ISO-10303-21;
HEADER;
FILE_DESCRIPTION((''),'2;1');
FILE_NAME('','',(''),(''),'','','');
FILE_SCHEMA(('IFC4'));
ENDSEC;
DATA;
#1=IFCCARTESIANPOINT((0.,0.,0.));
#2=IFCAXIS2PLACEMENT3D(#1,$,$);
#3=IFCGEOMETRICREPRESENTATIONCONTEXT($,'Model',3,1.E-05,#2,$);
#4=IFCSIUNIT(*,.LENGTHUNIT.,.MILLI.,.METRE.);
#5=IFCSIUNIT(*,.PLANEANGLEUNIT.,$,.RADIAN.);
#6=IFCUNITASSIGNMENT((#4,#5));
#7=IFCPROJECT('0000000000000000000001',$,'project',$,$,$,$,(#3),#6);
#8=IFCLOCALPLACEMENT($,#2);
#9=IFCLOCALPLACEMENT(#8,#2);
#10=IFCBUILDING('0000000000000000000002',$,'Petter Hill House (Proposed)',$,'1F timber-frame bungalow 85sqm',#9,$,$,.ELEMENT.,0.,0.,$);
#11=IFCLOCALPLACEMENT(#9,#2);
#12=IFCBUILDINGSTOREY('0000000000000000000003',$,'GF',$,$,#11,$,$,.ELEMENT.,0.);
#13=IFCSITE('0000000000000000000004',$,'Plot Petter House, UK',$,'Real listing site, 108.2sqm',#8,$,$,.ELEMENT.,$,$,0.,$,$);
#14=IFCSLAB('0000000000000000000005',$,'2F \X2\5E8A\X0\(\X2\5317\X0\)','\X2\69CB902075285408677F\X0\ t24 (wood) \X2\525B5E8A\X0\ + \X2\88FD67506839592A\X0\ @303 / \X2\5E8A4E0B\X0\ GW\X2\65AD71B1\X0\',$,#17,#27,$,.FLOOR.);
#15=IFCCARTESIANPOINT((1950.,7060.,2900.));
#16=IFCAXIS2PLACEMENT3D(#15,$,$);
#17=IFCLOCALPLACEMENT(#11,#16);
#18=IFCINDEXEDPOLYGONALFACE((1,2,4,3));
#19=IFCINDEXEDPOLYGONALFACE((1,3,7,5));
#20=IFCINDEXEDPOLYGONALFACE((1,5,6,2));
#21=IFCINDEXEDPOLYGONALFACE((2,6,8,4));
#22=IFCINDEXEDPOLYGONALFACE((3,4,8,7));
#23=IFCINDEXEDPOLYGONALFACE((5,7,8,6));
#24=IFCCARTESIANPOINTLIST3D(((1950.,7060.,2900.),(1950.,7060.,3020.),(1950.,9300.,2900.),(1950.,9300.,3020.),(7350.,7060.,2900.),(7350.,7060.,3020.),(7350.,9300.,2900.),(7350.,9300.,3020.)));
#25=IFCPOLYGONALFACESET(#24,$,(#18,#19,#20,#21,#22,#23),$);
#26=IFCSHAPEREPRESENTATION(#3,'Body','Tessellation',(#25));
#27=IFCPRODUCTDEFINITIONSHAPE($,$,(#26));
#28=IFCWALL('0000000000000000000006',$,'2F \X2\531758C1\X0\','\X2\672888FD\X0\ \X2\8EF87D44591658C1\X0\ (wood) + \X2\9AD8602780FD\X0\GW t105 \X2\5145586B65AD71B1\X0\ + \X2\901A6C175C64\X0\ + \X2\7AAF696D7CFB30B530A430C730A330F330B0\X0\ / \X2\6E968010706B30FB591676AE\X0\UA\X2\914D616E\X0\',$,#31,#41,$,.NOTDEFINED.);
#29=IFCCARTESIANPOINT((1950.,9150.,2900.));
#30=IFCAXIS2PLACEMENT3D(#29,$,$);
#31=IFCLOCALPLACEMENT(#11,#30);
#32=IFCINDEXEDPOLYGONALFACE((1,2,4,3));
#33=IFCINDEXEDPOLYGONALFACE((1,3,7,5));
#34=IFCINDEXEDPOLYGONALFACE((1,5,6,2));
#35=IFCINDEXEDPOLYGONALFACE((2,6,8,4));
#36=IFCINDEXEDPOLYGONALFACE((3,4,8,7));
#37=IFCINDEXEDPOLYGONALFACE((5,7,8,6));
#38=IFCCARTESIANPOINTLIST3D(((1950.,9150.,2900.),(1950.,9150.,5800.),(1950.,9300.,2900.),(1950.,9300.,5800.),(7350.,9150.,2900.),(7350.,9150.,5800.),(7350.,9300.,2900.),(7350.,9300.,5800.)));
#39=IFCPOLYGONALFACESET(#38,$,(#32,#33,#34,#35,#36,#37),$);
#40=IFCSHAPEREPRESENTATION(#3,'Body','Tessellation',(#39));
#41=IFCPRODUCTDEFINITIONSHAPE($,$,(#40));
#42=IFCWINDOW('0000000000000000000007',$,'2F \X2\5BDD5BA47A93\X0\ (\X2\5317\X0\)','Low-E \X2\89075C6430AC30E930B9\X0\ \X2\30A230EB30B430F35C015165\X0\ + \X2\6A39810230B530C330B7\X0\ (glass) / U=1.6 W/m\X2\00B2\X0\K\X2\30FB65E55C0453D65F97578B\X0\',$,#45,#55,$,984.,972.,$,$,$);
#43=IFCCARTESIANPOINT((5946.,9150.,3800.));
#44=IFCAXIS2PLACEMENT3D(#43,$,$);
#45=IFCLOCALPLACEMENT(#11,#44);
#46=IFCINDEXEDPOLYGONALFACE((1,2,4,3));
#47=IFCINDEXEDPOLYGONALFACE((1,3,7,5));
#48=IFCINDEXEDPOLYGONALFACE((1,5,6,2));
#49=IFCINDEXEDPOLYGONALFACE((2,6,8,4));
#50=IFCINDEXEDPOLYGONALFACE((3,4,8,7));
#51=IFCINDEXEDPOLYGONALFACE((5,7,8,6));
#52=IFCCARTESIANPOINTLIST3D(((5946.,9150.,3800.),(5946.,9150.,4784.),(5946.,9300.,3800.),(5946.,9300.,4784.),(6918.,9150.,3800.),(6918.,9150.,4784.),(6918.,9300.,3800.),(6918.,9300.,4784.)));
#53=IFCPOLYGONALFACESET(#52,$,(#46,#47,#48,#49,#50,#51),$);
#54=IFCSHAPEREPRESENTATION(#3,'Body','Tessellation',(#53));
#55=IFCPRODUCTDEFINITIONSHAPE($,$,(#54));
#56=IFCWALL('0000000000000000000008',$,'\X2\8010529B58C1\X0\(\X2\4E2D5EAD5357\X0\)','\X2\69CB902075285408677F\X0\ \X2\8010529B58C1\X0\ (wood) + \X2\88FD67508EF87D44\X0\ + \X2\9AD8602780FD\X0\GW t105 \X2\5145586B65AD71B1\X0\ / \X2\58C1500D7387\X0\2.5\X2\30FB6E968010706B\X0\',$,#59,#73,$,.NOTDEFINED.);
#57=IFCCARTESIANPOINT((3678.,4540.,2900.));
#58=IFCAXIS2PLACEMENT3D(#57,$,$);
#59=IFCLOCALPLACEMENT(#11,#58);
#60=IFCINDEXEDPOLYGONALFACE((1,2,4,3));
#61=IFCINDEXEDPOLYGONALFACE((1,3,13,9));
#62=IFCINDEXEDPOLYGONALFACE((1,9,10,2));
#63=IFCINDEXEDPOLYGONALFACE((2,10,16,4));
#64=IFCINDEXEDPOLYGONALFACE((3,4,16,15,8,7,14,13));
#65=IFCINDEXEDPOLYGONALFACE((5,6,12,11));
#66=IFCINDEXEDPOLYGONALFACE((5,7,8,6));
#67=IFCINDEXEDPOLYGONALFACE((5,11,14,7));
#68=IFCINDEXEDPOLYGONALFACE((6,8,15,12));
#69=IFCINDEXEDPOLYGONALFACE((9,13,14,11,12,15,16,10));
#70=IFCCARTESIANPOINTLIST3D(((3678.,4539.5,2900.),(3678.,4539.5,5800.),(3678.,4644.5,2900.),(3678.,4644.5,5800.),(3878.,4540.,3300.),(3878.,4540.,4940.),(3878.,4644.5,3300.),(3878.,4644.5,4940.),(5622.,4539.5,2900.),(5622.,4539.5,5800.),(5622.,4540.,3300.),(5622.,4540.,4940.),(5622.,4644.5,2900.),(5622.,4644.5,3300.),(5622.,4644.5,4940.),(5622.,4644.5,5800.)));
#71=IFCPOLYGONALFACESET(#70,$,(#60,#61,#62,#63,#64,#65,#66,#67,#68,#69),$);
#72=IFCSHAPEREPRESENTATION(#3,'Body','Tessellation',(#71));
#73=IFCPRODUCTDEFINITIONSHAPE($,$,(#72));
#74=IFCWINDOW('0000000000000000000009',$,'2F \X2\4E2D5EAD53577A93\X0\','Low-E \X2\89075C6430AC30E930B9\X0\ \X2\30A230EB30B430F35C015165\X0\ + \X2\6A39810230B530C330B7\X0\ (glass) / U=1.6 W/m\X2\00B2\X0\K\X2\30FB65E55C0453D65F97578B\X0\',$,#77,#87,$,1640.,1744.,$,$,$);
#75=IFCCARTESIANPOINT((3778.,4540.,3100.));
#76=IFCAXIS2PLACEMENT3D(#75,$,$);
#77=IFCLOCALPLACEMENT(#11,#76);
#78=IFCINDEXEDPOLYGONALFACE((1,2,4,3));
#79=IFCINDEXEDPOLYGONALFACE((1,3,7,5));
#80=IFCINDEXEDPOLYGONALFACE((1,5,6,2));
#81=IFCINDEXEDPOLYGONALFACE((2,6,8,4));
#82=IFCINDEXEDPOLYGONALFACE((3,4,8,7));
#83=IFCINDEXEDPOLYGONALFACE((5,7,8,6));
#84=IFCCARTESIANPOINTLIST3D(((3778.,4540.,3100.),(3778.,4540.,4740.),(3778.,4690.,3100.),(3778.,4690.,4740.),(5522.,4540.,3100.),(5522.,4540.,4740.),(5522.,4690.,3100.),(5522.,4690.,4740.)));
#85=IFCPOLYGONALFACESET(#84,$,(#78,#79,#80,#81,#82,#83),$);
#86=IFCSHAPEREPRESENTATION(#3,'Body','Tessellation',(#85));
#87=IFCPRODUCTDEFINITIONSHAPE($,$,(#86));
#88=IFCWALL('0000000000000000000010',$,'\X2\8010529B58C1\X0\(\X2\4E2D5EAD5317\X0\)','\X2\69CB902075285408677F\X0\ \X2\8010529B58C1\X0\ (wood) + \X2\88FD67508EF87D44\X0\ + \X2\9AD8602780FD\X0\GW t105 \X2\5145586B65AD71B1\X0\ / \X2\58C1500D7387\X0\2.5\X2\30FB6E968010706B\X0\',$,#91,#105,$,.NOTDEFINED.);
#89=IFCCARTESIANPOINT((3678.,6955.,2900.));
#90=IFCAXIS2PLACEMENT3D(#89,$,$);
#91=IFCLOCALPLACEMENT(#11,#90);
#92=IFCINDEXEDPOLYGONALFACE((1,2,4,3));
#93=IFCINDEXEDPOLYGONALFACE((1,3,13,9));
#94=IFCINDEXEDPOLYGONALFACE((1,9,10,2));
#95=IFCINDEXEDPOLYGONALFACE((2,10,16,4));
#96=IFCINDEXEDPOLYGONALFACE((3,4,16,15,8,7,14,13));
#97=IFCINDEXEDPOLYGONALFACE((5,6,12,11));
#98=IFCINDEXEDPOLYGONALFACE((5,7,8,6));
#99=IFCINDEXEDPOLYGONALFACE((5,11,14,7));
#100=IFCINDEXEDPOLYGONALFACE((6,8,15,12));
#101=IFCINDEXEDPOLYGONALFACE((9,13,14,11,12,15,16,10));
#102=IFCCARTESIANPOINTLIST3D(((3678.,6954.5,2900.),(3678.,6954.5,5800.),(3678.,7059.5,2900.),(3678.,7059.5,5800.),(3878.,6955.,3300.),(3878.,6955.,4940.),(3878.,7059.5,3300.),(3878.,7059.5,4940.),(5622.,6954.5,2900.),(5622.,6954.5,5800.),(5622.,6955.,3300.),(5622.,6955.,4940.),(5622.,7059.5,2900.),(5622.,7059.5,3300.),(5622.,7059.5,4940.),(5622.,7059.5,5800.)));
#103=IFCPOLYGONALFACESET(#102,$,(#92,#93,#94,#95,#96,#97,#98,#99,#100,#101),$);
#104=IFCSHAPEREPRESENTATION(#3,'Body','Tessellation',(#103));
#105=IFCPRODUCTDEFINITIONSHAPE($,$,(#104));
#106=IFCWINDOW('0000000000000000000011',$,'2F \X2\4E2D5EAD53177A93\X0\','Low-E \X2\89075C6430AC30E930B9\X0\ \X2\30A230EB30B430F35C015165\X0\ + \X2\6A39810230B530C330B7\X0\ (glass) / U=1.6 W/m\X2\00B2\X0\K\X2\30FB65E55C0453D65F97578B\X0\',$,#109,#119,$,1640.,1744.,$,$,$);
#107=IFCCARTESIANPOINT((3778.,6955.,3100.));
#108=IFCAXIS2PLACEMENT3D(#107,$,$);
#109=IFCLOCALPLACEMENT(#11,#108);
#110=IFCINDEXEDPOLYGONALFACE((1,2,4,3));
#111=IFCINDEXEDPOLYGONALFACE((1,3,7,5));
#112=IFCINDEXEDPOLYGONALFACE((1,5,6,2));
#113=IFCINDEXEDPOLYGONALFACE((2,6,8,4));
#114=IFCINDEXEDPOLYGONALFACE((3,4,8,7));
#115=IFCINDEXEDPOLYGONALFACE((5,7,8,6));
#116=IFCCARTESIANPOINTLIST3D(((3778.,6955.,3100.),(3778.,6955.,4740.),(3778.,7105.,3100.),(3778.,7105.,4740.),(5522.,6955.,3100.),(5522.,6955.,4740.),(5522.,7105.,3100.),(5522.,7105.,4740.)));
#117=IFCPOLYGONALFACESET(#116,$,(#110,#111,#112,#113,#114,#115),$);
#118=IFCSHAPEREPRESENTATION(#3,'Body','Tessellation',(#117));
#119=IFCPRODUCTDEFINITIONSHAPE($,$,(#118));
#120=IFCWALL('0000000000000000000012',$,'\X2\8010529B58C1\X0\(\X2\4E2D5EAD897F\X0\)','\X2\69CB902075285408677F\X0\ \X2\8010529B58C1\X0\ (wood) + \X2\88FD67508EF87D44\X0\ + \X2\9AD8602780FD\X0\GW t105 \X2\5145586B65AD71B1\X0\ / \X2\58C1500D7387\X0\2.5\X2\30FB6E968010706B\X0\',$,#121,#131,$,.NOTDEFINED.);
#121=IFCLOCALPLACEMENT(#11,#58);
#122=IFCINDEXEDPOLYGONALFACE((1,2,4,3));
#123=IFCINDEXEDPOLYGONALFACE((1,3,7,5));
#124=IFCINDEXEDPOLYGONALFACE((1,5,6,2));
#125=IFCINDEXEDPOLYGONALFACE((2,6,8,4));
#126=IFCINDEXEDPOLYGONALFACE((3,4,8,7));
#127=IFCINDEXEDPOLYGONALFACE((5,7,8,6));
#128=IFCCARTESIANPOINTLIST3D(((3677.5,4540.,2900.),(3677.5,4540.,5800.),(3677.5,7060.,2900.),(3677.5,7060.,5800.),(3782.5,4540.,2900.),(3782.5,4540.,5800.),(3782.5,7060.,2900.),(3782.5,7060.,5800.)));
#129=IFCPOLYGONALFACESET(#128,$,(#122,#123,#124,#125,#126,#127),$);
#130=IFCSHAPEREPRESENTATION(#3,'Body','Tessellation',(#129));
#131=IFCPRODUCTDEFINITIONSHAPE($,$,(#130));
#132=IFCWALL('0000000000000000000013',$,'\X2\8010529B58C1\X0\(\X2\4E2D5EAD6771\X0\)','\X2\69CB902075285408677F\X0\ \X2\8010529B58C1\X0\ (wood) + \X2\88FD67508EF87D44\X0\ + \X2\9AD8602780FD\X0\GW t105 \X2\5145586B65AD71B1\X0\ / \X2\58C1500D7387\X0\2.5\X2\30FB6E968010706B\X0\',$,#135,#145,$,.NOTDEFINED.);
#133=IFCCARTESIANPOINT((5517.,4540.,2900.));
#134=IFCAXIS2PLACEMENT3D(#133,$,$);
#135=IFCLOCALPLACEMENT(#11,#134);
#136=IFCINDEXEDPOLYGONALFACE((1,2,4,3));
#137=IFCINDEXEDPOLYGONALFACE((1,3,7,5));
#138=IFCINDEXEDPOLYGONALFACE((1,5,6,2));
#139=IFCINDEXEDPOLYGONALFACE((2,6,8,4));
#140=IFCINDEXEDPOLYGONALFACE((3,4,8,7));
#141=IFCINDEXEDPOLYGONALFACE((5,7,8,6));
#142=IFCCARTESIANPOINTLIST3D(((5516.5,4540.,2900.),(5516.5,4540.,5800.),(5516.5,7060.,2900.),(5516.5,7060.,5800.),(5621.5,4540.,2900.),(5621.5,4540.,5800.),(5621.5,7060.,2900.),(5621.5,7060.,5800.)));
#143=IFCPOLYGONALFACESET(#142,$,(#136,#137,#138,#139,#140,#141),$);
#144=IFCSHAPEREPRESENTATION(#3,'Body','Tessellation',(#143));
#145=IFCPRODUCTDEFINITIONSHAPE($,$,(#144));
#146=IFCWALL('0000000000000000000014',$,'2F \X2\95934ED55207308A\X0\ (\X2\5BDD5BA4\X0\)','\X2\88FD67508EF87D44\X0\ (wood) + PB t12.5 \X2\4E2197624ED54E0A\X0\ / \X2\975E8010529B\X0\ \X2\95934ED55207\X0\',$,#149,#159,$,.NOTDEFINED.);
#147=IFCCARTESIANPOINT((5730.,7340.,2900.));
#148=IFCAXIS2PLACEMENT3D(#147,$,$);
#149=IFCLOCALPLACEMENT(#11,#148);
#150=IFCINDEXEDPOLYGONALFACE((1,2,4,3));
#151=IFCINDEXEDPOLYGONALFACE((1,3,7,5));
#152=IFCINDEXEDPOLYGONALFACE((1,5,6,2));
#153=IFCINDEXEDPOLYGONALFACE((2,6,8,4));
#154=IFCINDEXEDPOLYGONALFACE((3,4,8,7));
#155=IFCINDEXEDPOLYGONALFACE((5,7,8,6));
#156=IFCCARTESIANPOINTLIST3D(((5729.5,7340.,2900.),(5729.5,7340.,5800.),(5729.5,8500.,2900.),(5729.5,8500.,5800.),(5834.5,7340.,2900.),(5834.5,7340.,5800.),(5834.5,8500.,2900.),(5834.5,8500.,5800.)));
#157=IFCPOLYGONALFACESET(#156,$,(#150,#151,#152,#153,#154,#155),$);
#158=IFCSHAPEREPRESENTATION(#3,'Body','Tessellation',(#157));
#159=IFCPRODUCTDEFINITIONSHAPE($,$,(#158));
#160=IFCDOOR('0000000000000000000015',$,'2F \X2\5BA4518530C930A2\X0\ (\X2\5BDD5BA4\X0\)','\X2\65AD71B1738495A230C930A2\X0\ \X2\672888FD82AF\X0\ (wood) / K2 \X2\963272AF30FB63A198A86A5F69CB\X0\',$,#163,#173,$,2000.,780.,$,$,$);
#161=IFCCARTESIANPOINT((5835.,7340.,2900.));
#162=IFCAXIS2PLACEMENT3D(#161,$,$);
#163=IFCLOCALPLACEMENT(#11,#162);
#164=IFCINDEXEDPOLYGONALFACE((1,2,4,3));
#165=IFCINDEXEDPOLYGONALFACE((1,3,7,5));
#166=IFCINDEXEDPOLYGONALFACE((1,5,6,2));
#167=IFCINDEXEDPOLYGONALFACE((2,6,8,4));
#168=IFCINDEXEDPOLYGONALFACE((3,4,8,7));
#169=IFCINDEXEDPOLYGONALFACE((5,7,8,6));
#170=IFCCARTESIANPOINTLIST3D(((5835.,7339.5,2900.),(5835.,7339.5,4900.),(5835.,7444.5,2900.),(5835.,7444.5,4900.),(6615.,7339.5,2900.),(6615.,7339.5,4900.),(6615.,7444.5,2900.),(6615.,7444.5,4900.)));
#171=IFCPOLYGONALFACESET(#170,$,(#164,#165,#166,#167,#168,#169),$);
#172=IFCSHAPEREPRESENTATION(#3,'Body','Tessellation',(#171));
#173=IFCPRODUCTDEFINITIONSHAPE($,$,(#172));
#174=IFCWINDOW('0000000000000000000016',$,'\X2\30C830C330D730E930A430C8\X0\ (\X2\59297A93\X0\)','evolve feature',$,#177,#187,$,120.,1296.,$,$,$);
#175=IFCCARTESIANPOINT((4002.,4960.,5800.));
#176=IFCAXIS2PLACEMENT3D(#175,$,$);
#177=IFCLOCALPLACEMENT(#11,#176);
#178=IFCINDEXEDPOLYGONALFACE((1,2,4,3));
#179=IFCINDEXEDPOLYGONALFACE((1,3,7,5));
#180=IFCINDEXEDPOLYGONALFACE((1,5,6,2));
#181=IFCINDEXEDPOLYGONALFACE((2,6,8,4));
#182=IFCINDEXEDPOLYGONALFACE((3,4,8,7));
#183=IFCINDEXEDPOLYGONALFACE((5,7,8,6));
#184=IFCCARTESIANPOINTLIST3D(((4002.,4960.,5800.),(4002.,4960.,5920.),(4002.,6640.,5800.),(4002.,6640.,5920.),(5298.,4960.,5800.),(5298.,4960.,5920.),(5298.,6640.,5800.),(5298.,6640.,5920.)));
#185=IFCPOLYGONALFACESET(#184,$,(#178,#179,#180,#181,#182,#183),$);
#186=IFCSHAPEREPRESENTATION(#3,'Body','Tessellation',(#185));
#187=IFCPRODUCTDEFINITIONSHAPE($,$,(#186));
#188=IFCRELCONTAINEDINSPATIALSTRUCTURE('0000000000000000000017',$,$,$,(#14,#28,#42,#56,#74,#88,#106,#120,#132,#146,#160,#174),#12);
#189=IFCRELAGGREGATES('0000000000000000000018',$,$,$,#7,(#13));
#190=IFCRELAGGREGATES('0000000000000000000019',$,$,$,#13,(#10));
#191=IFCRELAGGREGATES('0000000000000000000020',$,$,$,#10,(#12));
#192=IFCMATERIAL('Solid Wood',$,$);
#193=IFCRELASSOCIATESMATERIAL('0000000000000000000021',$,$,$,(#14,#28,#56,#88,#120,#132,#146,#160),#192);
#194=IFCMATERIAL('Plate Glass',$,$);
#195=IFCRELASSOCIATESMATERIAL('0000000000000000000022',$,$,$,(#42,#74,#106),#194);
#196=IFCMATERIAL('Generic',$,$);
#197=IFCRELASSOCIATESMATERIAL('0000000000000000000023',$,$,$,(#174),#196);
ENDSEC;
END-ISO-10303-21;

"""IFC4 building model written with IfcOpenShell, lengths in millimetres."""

from ifc_helpers import new_model, si_unit, frame, frame_2d, origin, place, context, project, spatial, rectangle, extrude, material, element, fill, save


model = new_model("IFC4")

# Units and contexts
model_context = context("Model", 3, precision=1e-05, world=origin())
ifc_project = project(units=[si_unit("LENGTHUNIT", "METRE", prefix="MILLI"), si_unit("PLANEANGLEUNIT", "RADIAN")], contexts=[model_context])

# Site, building, storey
site_placement = place(None, origin())
site = spatial("IfcSite", under=ifc_project, at=site_placement, Name="Plot Petter House, UK", ObjectType="Real listing site, 108.2sqm", CompositionType="ELEMENT", RefElevation=0.0)
building_placement = place(site_placement, origin())
building = spatial("IfcBuilding", under=site, at=building_placement, Name="Petter Hill House (Proposed)", ObjectType="1F timber-frame bungalow 85sqm", CompositionType="ELEMENT", ElevationOfRefHeight=0.0, ElevationOfTerrain=0.0)
storey_placement = place(building_placement, origin())
storey = spatial("IfcBuildingStorey", under=building, at=storey_placement, Name="GF", CompositionType="ELEMENT", Elevation=0.0)

# Slab
ifc_material_1 = material(Name="Solid Wood")
slab_placement = place(storey_placement, frame((1950.0, 7060.0, 2900.0)))
element("IfcSlab", 1, at=slab_placement, inside=storey, material=ifc_material_1, Name="2F 床(北)", Description="構造用合板 t24 (wood) 剛床 + 製材根太 @303 / 床下 GW断熱", PredefinedType="FLOOR", context=model_context, shape_type="SweptSolid", body=[
    extrude(rectangle(XDim=5400.0, YDim=2240.0, at=frame_2d((2700.0, 1120.0))), frame((1950.0, 7060.0, 2900.0)), (0.0, 0.0, 1.0), 120.0),
])

# Walls, openings, windows
wall_1_placement = place(storey_placement, frame((1950.0, 9150.0, 2900.0)))
wall_1 = element("IfcWall", 2, at=wall_1_placement, inside=storey, material=ifc_material_1, Name="2F 北壁", Description="木製 軸組外壁 (wood) + 高性能GW t105 充填断熱 + 通気層 + 窯業系サイディング / 準耐火・外皮UA配慮", PredefinedType="NOTDEFINED", context=model_context, shape_type="SweptSolid", body=[
    extrude(rectangle(XDim=5400.0, YDim=150.0, at=frame_2d((2700.0, 75.0))), frame((1950.0, 9150.0, 2900.0)), (0.0, 0.0, 1.0), 2900.0),
])
opening_1_placement = place(storey_placement, frame((5946.0, 9150.0, 3800.0)))
opening_1 = element("IfcOpeningElement", 3, at=opening_1_placement, cuts=wall_1, PredefinedType="NOTDEFINED", context=model_context, shape_type="SweptSolid", body=[
    extrude(rectangle(XDim=972.0, YDim=150.0, at=frame_2d((486.0, 75.0))), frame((5946.0, 9150.0, 3800.0)), (0.0, 0.0, 1.0), 984.0),
])
ifc_material_2 = material(Name="Plate Glass")
window_1_placement = place(storey_placement, frame((5946.0, 9150.0, 3800.0)))
window_1 = element("IfcWindow", 4, at=window_1_placement, inside=storey, material=ifc_material_2, Name="2F 寝室窓 (北)", Description="Low-E 複層ガラス アルゴン封入 + 樹脂サッシ (glass) / U=1.6 W/m²K・日射取得型", OverallHeight=984.0, OverallWidth=972.0, context=model_context, shape_type="SweptSolid", body=[
    extrude(rectangle(XDim=972.0, YDim=150.0, at=frame_2d((486.0, 75.0))), frame((5946.0, 9150.0, 3800.0)), (0.0, 0.0, 1.0), 984.0),
])
fill(opening_1, window_1)
wall_2_placement = place(storey_placement, frame((3678.0, 4540.0, 2900.0)))
wall_2 = element("IfcWall", 5, at=wall_2_placement, inside=storey, material=ifc_material_1, Name="耐力壁(中庭南)", Description="構造用合板 耐力壁 (wood) + 製材軸組 + 高性能GW t105 充填断熱 / 壁倍率2.5・準耐火", PredefinedType="NOTDEFINED", context=model_context, shape_type="SweptSolid", body=[
    extrude(rectangle(XDim=1944.0, YDim=105.0, at=frame_2d((972.0, 52.0))), frame((3678.0, 4540.0, 2900.0)), (0.0, 0.0, 1.0), 2900.0),
])
opening_2_placement = place(storey_placement, frame((3778.0, 4540.0, 3100.0)))
opening_2 = element("IfcOpeningElement", 6, at=opening_2_placement, cuts=wall_2, PredefinedType="NOTDEFINED", context=model_context, shape_type="SweptSolid", body=[
    extrude(rectangle(XDim=1744.0, YDim=150.0, at=frame_2d((872.0, 75.0))), frame((3778.0, 4540.0, 3100.0)), (0.0, 0.0, 1.0), 1640.0),
])
window_2_placement = place(storey_placement, frame((3778.0, 4540.0, 3100.0)))
window_2 = element("IfcWindow", 7, at=window_2_placement, inside=storey, material=ifc_material_2, Name="2F 中庭南窓", Description="Low-E 複層ガラス アルゴン封入 + 樹脂サッシ (glass) / U=1.6 W/m²K・日射取得型", OverallHeight=1640.0, OverallWidth=1744.0, context=model_context, shape_type="SweptSolid", body=[
    extrude(rectangle(XDim=1744.0, YDim=150.0, at=frame_2d((872.0, 75.0))), frame((3778.0, 4540.0, 3100.0)), (0.0, 0.0, 1.0), 1640.0),
])
fill(opening_2, window_2)
wall_3_placement = place(storey_placement, frame((3678.0, 6955.0, 2900.0)))
wall_3 = element("IfcWall", 8, at=wall_3_placement, inside=storey, material=ifc_material_1, Name="耐力壁(中庭北)", Description="構造用合板 耐力壁 (wood) + 製材軸組 + 高性能GW t105 充填断熱 / 壁倍率2.5・準耐火", PredefinedType="NOTDEFINED", context=model_context, shape_type="SweptSolid", body=[
    extrude(rectangle(XDim=1944.0, YDim=105.0, at=frame_2d((972.0, 52.0))), frame((3678.0, 6955.0, 2900.0)), (0.0, 0.0, 1.0), 2900.0),
])
opening_3_placement = place(storey_placement, frame((3778.0, 6955.0, 3100.0)))
opening_3 = element("IfcOpeningElement", 9, at=opening_3_placement, cuts=wall_3, PredefinedType="NOTDEFINED", context=model_context, shape_type="SweptSolid", body=[
    extrude(rectangle(XDim=1744.0, YDim=150.0, at=frame_2d((872.0, 75.0))), frame((3778.0, 6955.0, 3100.0)), (0.0, 0.0, 1.0), 1640.0),
])
window_3_placement = place(storey_placement, frame((3778.0, 6955.0, 3100.0)))
window_3 = element("IfcWindow", 10, at=window_3_placement, inside=storey, material=ifc_material_2, Name="2F 中庭北窓", Description="Low-E 複層ガラス アルゴン封入 + 樹脂サッシ (glass) / U=1.6 W/m²K・日射取得型", OverallHeight=1640.0, OverallWidth=1744.0, context=model_context, shape_type="SweptSolid", body=[
    extrude(rectangle(XDim=1744.0, YDim=150.0, at=frame_2d((872.0, 75.0))), frame((3778.0, 6955.0, 3100.0)), (0.0, 0.0, 1.0), 1640.0),
])
fill(opening_3, window_3)

# Walls
wall_4_placement = place(storey_placement, frame((3678.0, 4540.0, 2900.0)))
element("IfcWall", 11, at=wall_4_placement, inside=storey, material=ifc_material_1, Name="耐力壁(中庭西)", Description="構造用合板 耐力壁 (wood) + 製材軸組 + 高性能GW t105 充填断熱 / 壁倍率2.5・準耐火", PredefinedType="NOTDEFINED", context=model_context, shape_type="SweptSolid", body=[
    extrude(rectangle(XDim=105.0, YDim=2520.0, at=frame_2d((52.0, 1260.0))), frame((3678.0, 4540.0, 2900.0)), (0.0, 0.0, 1.0), 2900.0),
])
wall_5_placement = place(storey_placement, frame((5517.0, 4540.0, 2900.0)))
element("IfcWall", 12, at=wall_5_placement, inside=storey, material=ifc_material_1, Name="耐力壁(中庭東)", Description="構造用合板 耐力壁 (wood) + 製材軸組 + 高性能GW t105 充填断熱 / 壁倍率2.5・準耐火", PredefinedType="NOTDEFINED", context=model_context, shape_type="SweptSolid", body=[
    extrude(rectangle(XDim=105.0, YDim=2520.0, at=frame_2d((52.0, 1260.0))), frame((5517.0, 4540.0, 2900.0)), (0.0, 0.0, 1.0), 2900.0),
])
wall_6_placement = place(storey_placement, frame((5730.0, 7340.0, 2900.0)))
element("IfcWall", 13, at=wall_6_placement, inside=storey, material=ifc_material_1, Name="2F 間仕切り (寝室)", Description="製材軸組 (wood) + PB t12.5 両面仕上 / 非耐力 間仕切", PredefinedType="NOTDEFINED", context=model_context, shape_type="SweptSolid", body=[
    extrude(rectangle(XDim=105.0, YDim=1160.0, at=frame_2d((52.0, 580.0))), frame((5730.0, 7340.0, 2900.0)), (0.0, 0.0, 1.0), 2900.0),
])

# Door
door_placement = place(storey_placement, frame((5835.0, 7340.0, 2900.0)))
element("IfcDoor", 14, at=door_placement, inside=storey, material=ifc_material_1, Name="2F 室内ドア (寝室)", Description="断熱玄関ドア 木製芯 (wood) / K2 防犯・採風機構", OverallHeight=2000.0, OverallWidth=780.0, context=model_context, shape_type="SweptSolid", body=[
    extrude(rectangle(XDim=780.0, YDim=105.0, at=frame_2d((390.0, 52.0))), frame((5835.0, 7340.0, 2900.0)), (0.0, 0.0, 1.0), 2000.0),
])

# Window
ifc_material_3 = material(Name="Generic")
window_4_placement = place(storey_placement, frame((4002.0, 4960.0, 5800.0)))
element("IfcWindow", 15, at=window_4_placement, inside=storey, material=ifc_material_3, Name="トップライト (天窓)", Description="evolve feature", OverallHeight=120.0, OverallWidth=1296.0, context=model_context, shape_type="SweptSolid", body=[
    extrude(rectangle(XDim=1296.0, YDim=1680.0, at=frame_2d((648.0, 840.0))), frame((4002.0, 4960.0, 5800.0)), (0.0, 0.0, 1.0), 120.0),
])

save(model, "model.ifc")
